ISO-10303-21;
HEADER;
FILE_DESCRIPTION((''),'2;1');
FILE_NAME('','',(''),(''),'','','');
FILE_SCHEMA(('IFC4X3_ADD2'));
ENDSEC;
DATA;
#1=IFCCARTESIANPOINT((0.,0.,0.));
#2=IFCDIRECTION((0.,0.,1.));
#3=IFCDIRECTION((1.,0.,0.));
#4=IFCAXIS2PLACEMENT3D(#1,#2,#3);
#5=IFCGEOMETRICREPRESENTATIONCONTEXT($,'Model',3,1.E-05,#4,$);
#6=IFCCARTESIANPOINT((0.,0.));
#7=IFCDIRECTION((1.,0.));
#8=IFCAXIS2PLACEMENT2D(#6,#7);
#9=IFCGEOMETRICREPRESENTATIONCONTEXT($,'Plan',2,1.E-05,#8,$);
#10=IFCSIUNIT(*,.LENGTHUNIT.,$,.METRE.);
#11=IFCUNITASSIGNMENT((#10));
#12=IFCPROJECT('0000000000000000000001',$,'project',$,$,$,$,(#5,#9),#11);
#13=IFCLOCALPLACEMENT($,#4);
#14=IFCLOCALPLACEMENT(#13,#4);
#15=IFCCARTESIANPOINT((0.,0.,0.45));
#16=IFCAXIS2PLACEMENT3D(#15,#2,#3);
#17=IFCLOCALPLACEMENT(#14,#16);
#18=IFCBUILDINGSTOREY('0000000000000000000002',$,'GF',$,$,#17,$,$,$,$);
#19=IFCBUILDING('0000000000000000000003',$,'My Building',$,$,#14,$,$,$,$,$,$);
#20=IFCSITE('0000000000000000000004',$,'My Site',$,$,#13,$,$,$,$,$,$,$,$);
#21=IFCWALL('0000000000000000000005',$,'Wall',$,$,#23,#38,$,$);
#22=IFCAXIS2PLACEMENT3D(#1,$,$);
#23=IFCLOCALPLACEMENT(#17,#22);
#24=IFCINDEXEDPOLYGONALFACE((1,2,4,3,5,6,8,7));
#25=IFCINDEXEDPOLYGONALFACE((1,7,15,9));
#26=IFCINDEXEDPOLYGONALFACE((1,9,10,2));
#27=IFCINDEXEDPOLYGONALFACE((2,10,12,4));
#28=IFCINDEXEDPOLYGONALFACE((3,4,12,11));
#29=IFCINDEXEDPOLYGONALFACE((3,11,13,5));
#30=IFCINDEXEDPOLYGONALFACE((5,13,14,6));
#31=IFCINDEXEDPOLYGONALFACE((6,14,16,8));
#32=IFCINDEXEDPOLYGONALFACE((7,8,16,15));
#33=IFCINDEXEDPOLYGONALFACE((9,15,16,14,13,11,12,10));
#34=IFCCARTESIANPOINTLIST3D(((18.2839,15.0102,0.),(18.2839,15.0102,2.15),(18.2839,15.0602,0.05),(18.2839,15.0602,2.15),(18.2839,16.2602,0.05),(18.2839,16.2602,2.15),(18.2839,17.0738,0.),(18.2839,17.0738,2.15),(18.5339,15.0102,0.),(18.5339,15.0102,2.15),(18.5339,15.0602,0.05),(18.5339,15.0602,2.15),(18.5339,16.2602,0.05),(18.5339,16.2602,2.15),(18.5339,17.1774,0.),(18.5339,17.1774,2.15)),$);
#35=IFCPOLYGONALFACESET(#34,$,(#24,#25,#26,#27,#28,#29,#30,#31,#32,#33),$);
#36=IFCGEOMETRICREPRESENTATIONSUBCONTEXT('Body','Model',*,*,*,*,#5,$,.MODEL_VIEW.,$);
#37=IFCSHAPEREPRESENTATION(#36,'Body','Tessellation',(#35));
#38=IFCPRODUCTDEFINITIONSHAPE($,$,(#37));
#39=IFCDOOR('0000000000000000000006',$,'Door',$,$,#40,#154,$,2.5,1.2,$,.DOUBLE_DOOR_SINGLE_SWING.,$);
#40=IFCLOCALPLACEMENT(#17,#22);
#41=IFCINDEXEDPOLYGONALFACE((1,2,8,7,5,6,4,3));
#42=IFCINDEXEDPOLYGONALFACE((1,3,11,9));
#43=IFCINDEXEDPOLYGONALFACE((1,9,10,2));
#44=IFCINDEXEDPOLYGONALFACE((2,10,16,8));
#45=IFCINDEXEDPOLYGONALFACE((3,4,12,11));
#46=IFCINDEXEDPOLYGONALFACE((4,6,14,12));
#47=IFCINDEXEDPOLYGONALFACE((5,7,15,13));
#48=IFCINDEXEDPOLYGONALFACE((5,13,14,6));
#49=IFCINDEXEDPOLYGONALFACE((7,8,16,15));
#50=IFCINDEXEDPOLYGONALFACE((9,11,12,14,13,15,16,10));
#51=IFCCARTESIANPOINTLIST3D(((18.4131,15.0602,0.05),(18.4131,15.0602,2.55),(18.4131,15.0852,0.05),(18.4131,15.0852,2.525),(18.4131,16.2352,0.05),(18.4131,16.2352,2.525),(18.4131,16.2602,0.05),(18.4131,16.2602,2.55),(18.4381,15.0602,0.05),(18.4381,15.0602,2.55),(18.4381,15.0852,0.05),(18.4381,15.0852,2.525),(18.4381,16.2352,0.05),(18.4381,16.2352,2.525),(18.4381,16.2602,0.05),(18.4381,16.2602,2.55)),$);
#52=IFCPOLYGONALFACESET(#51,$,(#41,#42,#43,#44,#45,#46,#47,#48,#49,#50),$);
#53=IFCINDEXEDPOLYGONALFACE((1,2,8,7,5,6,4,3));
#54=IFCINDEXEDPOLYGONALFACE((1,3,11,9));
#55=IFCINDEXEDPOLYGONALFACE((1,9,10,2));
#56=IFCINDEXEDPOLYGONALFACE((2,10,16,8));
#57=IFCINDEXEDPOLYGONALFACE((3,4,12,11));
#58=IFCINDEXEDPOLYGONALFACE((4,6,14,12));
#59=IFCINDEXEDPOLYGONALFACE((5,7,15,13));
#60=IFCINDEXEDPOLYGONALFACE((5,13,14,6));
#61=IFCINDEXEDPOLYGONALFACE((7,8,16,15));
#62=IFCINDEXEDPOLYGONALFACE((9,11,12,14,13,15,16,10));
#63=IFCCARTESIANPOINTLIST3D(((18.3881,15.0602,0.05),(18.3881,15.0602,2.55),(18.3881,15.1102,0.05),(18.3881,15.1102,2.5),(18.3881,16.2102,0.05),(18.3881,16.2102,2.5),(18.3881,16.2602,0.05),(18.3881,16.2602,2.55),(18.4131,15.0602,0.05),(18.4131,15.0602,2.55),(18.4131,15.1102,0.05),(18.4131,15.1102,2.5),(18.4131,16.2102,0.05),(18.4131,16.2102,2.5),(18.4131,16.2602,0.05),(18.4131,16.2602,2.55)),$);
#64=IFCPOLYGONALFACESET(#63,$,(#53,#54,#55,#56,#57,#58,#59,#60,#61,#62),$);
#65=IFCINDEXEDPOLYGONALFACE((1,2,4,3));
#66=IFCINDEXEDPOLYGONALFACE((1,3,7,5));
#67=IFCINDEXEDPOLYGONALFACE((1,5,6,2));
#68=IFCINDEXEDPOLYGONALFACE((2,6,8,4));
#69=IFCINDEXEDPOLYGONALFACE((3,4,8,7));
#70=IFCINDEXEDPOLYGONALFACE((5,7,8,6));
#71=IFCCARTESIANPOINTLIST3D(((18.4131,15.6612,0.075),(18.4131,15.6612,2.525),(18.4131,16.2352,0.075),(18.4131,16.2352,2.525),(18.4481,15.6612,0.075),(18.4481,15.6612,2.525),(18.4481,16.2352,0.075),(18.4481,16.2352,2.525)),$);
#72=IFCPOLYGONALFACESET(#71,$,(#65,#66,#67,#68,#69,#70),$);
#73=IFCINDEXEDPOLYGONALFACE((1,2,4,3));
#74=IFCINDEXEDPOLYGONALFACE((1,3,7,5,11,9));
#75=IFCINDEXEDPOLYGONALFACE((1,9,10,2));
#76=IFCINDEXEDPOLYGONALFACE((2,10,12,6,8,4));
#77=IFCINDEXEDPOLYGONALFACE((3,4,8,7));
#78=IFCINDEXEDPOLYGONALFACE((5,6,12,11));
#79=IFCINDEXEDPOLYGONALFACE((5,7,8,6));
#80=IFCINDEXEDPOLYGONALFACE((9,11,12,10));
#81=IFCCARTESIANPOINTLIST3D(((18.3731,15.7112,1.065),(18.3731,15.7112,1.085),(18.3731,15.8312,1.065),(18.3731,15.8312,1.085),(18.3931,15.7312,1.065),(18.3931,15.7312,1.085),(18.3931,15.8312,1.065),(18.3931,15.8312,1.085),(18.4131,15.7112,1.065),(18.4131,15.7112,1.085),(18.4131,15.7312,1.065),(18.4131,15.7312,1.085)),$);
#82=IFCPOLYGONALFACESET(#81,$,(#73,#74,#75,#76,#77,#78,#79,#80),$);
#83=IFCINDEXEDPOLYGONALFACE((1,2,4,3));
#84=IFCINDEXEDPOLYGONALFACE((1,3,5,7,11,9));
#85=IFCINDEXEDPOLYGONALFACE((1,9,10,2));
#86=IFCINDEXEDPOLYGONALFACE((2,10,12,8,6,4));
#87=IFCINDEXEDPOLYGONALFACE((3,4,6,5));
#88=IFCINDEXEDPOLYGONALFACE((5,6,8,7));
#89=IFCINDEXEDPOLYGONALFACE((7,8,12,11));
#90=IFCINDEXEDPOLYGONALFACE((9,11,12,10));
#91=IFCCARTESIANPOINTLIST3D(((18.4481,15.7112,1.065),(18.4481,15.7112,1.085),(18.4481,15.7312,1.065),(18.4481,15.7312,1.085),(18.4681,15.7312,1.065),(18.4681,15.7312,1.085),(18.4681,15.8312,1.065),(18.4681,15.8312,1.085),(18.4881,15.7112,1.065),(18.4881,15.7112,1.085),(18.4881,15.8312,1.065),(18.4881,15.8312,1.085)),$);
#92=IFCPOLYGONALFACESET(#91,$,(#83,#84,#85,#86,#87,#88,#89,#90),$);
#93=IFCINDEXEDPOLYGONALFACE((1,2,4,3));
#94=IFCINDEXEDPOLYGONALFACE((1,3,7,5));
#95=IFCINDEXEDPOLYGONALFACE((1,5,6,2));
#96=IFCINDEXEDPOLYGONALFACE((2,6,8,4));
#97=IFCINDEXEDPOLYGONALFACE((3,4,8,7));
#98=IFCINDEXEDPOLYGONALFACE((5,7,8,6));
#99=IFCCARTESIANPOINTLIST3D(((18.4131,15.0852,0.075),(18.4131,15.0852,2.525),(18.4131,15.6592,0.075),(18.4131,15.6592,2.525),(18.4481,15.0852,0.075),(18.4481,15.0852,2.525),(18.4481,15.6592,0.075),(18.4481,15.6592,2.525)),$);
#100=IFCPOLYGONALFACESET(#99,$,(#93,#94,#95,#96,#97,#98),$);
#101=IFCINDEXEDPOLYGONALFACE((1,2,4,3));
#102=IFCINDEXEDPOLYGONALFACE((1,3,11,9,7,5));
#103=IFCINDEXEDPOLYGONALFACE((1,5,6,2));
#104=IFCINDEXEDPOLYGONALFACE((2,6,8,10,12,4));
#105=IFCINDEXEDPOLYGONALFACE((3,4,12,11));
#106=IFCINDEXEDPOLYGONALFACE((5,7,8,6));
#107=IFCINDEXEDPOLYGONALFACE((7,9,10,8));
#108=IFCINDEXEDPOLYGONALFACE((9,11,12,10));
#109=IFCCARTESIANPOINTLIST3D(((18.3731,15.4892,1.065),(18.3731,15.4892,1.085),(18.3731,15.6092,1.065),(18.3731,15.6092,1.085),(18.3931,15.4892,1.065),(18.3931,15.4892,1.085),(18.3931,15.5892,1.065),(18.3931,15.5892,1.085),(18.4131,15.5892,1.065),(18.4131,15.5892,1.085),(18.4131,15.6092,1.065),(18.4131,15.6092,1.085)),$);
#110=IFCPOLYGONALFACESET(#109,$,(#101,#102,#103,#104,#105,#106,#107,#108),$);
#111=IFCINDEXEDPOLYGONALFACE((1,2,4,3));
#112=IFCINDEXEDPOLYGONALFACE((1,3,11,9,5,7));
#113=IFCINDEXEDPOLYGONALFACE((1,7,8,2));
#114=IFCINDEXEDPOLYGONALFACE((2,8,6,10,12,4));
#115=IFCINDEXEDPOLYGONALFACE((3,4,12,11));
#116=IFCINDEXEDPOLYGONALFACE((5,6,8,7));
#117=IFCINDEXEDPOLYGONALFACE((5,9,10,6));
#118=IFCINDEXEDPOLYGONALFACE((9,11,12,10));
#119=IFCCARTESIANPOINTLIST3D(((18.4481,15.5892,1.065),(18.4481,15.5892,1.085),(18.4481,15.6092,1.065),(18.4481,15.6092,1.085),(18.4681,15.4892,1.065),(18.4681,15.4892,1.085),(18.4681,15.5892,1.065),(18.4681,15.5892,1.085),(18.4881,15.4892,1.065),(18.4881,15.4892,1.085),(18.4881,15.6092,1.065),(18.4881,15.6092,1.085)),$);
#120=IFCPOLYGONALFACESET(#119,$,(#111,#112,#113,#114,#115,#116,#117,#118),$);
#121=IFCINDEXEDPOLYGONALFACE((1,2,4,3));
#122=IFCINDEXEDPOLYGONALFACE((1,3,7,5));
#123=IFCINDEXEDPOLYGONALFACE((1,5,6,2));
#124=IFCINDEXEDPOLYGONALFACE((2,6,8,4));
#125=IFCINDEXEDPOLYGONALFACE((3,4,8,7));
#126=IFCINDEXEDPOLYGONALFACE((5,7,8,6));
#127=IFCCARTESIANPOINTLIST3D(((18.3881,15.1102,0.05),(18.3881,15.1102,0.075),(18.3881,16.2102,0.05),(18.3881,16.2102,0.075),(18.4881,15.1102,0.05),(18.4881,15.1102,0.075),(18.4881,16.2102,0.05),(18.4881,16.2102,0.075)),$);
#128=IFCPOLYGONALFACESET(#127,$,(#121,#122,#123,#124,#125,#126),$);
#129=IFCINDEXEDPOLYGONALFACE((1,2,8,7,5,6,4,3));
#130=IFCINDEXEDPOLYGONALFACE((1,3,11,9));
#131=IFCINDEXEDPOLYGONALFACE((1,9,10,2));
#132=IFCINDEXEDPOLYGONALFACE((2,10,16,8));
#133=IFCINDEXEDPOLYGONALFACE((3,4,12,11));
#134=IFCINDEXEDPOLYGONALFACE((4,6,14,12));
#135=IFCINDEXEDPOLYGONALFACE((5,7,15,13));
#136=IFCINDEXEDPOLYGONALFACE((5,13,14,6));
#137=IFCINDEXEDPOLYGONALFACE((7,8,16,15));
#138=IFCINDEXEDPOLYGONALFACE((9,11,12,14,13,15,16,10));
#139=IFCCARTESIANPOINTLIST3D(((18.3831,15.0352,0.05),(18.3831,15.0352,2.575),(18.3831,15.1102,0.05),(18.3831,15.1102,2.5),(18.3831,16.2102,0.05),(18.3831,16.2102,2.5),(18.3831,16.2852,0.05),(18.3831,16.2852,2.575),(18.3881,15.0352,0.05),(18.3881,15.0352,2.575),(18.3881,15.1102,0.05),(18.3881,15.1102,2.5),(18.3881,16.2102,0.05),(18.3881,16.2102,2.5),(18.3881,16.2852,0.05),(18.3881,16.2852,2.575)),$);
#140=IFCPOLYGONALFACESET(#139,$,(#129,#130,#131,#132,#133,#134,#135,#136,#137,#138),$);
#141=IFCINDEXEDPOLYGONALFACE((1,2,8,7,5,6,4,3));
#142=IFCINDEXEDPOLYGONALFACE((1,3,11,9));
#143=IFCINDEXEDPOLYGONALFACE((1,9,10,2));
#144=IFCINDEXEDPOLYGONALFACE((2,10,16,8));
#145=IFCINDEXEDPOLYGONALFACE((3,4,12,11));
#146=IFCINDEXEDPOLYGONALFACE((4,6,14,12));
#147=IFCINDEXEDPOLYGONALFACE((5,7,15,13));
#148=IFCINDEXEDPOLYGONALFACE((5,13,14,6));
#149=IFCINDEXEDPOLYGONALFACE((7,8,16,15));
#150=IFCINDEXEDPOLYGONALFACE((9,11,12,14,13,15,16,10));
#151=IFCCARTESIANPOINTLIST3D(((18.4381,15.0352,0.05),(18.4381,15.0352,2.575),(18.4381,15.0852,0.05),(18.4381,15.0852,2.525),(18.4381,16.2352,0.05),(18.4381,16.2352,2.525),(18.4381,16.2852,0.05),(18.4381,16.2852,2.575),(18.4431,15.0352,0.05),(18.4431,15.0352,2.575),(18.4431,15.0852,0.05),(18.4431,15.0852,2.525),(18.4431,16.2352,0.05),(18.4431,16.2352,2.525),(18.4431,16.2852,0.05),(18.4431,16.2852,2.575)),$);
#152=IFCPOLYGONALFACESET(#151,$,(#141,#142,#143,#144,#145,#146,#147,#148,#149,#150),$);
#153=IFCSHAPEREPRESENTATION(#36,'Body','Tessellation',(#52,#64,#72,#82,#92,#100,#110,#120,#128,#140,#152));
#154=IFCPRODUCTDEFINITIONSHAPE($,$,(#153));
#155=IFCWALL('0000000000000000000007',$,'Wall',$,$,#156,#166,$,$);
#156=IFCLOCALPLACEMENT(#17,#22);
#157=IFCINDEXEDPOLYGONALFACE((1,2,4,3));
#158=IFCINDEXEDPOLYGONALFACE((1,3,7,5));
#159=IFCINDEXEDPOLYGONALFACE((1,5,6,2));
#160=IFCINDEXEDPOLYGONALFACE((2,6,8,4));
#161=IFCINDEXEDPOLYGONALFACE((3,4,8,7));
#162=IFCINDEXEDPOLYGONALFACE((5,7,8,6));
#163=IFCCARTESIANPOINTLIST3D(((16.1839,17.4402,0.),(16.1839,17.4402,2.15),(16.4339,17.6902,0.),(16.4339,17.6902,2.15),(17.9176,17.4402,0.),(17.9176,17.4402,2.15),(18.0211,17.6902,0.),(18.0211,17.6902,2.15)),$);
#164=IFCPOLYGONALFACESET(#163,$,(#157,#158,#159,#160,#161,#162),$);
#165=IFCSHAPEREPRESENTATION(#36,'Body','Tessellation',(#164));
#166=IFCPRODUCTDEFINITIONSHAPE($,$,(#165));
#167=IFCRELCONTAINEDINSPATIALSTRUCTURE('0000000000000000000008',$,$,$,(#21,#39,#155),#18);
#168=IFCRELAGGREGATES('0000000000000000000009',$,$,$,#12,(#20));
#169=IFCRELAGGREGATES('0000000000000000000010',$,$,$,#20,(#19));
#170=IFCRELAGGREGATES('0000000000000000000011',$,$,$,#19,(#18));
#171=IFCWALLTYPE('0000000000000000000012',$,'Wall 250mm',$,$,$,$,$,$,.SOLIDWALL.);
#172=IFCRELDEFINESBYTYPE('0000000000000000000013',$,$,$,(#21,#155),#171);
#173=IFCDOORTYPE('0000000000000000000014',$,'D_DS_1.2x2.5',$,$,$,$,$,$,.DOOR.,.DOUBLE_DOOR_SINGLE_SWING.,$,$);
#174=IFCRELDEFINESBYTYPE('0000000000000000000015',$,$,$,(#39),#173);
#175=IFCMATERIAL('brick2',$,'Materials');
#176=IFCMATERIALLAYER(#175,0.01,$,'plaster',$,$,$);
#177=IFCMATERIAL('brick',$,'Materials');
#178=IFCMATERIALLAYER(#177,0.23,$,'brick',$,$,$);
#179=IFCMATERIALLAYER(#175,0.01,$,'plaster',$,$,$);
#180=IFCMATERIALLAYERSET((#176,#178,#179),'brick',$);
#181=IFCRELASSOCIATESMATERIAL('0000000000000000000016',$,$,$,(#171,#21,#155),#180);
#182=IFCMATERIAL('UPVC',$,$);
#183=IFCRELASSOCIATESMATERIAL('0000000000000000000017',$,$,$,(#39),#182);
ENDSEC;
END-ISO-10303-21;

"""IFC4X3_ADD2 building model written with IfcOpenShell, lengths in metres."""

from ifc_helpers import new_model, entity, si_unit, frame, origin_with_axes, origin_2d_with_axis, place, context, subcontext, project, spatial, line, indexed_curve, outline, extrude, shape, source, transform, mapped, material, layer, layer_set, layer_usage, type_object, type_shapes, element, fill, save


model = new_model("IFC4X3_ADD2")

# Units and contexts
model_context = context("Model", 3, precision=1e-05, world=origin_with_axes())
plan_context = context("Plan", 2, precision=1e-05, world=origin_2d_with_axis())
body_context_1 = subcontext(model_context, "Body", "Model", "MODEL_VIEW")
body_context_2 = subcontext(plan_context, "Body", "Plan", "PLAN_VIEW")
ifc_project = project(units=[si_unit("LENGTHUNIT", "METRE")], contexts=[model_context, plan_context])

# Site, building, storey
site_placement = place(None, origin_with_axes())
site = spatial("IfcSite", under=ifc_project, at=site_placement, Name="My Site")
building_placement = place(site_placement, origin_with_axes())
building = spatial("IfcBuilding", under=site, at=building_placement, Name="My Building")
storey_placement = place(building_placement, frame((0.0, 0.0, 0.45), z_axis=(0.0, 0.0, 1.0), x_axis=(1.0, 0.0, 0.0)))
storey = spatial("IfcBuildingStorey", under=building, at=storey_placement, Name="GF")

# Shared definitions
ifc_material_1 = material(Name="UPVC")

# Wall, opening, door
ifc_material_2 = material(Name="brick2", Category="Materials")
ifc_layer_1 = layer(ifc_material_2, 0.01, Name="plaster")
ifc_material_3 = material(Name="brick", Category="Materials")
ifc_layer_2 = layer(ifc_material_3, 0.23, Name="brick")
ifc_layer_3 = layer(ifc_material_2, 0.01, Name="plaster")
ifc_layer_set_1 = layer_set([ifc_layer_1, ifc_layer_2, ifc_layer_3], Name="brick")
ifc_layer_usage_1 = layer_usage(ifc_layer_set_1, "AXIS2", "NEGATIVE", 0.0)
wall_type = type_object("IfcWallType", Name="Wall 250mm", PredefinedType="SOLIDWALL", material=ifc_layer_set_1)
wall_1_placement = place(storey_placement, frame((18.2839, 15.0102, 0.0), z_axis=(0.0, 0.0, 1.0), x_axis=(0.000001, 1.0, 0.0)))
wall_1 = element("IfcWall", 1, at=wall_1_placement, inside=storey, type_object=wall_type, material=ifc_layer_usage_1, Name="Wall", context=body_context_1, shape_type="SweptSolid", body=[
    extrude(outline(indexed_curve([(0.0, -0.25), (0.0, 0.0), (2.0636, 0.0), (2.1672, -0.25)], segments=[line(1, 2, 3, 4, 1)])), origin_with_axes(), (0.0, 0.0, 1.0), 2.15),
])
shared_shape_1 = source(origin_with_axes(), body_context_1, "Body", "SweptSolid", [
    extrude(outline(indexed_curve([(0.0, 0.0), (1.2, 0.0), (1.2, 2.5), (0.0, 2.5)], segments=[line(1, 2, 3, 4, 1)])), frame((0.0, -0.6, 0.0), z_axis=(0.0, -1.0, 0.0), x_axis=(1.0, 0.0, 0.0)), (0.0, 0.0, -1.0), 1.2),
])
opening_placement = place(wall_1_placement, frame((1.25, -0.1042, 0.05), z_axis=(0.0, 0.0, 1.0), x_axis=(-1.0, 0.0, 0.0)))
opening = element("IfcOpeningElement", 2, at=opening_placement, cuts=wall_1, PredefinedType="OPENING", context=body_context_1, shape_type="MappedRepresentation", body=[
    mapped(shared_shape_1, transform((0.0, 0.0, 0.0), x_axis=(1.0, 0.0, 0.0), y_axis=(0.0, 1.0, 0.0), z_axis=(0.0, 0.0, 1.0), scale=1.0)),
])
door_type = type_object("IfcDoorType", Name="D_DS_1.2x2.5", OperationType="DOUBLE_DOOR_SINGLE_SWING", PredefinedType="DOOR")
shared_shape_2 = source(origin_with_axes(), body_context_1, "Body", "SweptSolid", [
    extrude(outline(indexed_curve([(0.0, 0.0), (0.0, 2.5), (1.2, 2.5), (1.2, 0.0), (1.175, 0.0), (1.175, 2.475), (0.025, 2.475), (0.025, 0.0)], segments=[line(1, 2, 3, 4, 5, 6, 7, 8, 1)])), frame((0.0, 0.025, 0.0), z_axis=(0.0, -1.0, 0.0), x_axis=(1.0, 0.0, 0.0)), (0.0, 0.0, -1.0), 0.025),
    extrude(outline(indexed_curve([(0.0, 0.0), (0.0, 2.5), (1.2, 2.5), (1.2, 0.0), (1.15, 0.0), (1.15, 2.45), (0.05, 2.45), (0.05, 0.0)], segments=[line(1, 2, 3, 4, 5, 6, 7, 8, 1)])), frame((0.0, 0.0, 0.0), z_axis=(0.0, -1.0, 0.0), x_axis=(1.0, 0.0, 0.0)), (0.0, 0.0, -1.0), 0.025),
    extrude(outline(indexed_curve([(0.0, 0.0), (0.574, 0.0), (0.574, 0.035), (0.0, 0.035)], segments=[line(1, 2, 3, 4, 1)])), frame((0.025, 0.025, 0.025), z_axis=(0.0, 0.0, 1.0), x_axis=(1.0, 0.0, 0.0)), (0.0, 0.0, 1.0), 2.45),
    extrude(outline(indexed_curve([(0.0, 0.0), (0.0, -0.04), (-0.12, -0.04), (-0.12, -0.02), (-0.02, -0.02), (-0.02, 0.0)], segments=[line(1, 2, 3, 4, 5, 6, 1)])), frame((0.549, 0.025, 1.015), z_axis=(0.0, 0.0, 1.0), x_axis=(1.0, 0.0, 0.0)), (0.0, 0.0, 1.0), 0.02),
    extrude(outline(indexed_curve([(0.0, 0.0), (0.0, 0.04), (-0.12, 0.04), (-0.12, 0.02), (-0.02, 0.02), (-0.02, 0.0)], segments=[line(1, 2, 3, 4, 5, 6, 1)])), frame((0.549, 0.06, 1.015), z_axis=(0.0, 0.0, 1.0), x_axis=(1.0, 0.0, 0.0)), (0.0, 0.0, 1.0), 0.02),
    extrude(outline(indexed_curve([(0.0, 0.0), (-0.574, 0.0), (-0.574, 0.035), (0.0, 0.035)], segments=[line(1, 2, 3, 4, 1)])), frame((1.175, 0.025, 0.025), z_axis=(0.0, 0.0, 1.0), x_axis=(1.0, 0.0, 0.0)), (0.0, 0.0, 1.0), 2.45),
    extrude(outline(indexed_curve([(0.0, 0.0), (0.0, -0.04), (0.12, -0.04), (0.12, -0.02), (0.02, -0.02), (0.02, 0.0)], segments=[line(1, 2, 3, 4, 5, 6, 1)])), frame((0.651, 0.025, 1.015), z_axis=(0.0, 0.0, 1.0), x_axis=(1.0, 0.0, 0.0)), (0.0, 0.0, 1.0), 0.02),
    extrude(outline(indexed_curve([(0.0, 0.0), (0.0, 0.04), (0.12, 0.04), (0.12, 0.02), (0.02, 0.02), (0.02, 0.0)], segments=[line(1, 2, 3, 4, 5, 6, 1)])), frame((0.651, 0.06, 1.015), z_axis=(0.0, 0.0, 1.0), x_axis=(1.0, 0.0, 0.0)), (0.0, 0.0, 1.0), 0.02),
    extrude(outline(indexed_curve([(0.0, 0.0), (1.1, 0.0), (1.1, 0.1), (0.0, 0.1)], segments=[line(1, 2, 3, 4, 1)])), frame((0.05, 0.0, 0.0), z_axis=(0.0, 0.0, 1.0), x_axis=(1.0, 0.0, 0.0)), (0.0, 0.0, 1.0), 0.025),
    extrude(outline(indexed_curve([(0.0, 0.0), (0.0, 2.525), (1.25, 2.525), (1.25, 0.0), (1.175, 0.0), (1.175, 2.45), (0.075, 2.45), (0.075, 0.0)], segments=[line(1, 2, 3, 4, 5, 6, 7, 8, 1)])), frame((-0.025, -0.005, 0.0), z_axis=(0.0, -1.0, 0.0), x_axis=(1.0, 0.0, 0.0)), (0.0, 0.0, -1.0), 0.005),
    extrude(outline(indexed_curve([(0.0, 0.0), (0.0, 2.525), (1.25, 2.525), (1.25, 0.0), (1.2, 0.0), (1.2, 2.475), (0.05, 2.475), (0.05, 0.0)], segments=[line(1, 2, 3, 4, 5, 6, 7, 8, 1)])), frame((-0.025, 0.05, 0.0), z_axis=(0.0, -1.0, 0.0), x_axis=(1.0, 0.0, 0.0)), (0.0, 0.0, -1.0), 0.005),
])
shared_shape_3 = source(origin_with_axes(), body_context_2, "Body", "Curve2D", [
    entity("IfcIndexedPolyCurve", entity("IfcCartesianPointList2D", [[0.0, 0.0], [0.0, 0.05], [0.025, 0.05], [0.025, 0.025], [0.05, 0.025], [0.05, 0.0]]), [entity("IfcLineIndex", [1, 2, 3, 4, 5, 6, 1])]),
    entity("IfcIndexedPolyCurve", entity("IfcCartesianPointList2D", [[1.2, 0.0], [1.2, 0.05], [1.175, 0.05], [1.175, 0.025], [1.15, 0.025], [1.15, 0.0]]), [entity("IfcLineIndex", [1, 2, 3, 4, 5, 6, 1])]),
    entity("IfcTrimmedCurve", entity("IfcEllipse", entity("IfcAxis2Placement2D", entity("IfcCartesianPoint", [0.06, 0.05]), entity("IfcDirection", [1.0, 0.0])), 0.54, 0.575), [entity("IfcCartesianPoint", [0.6, 0.05])], [entity("IfcCartesianPoint", [0.06, 0.625])], True, "CARTESIAN"),
    entity("IfcIndexedPolyCurve", entity("IfcCartesianPointList2D", [[0.025, 0.05], [0.06, 0.05], [0.06, 0.625], [0.025, 0.625]]), [entity("IfcLineIndex", [1, 2, 3, 4, 1])]),
    entity("IfcTrimmedCurve", entity("IfcEllipse", entity("IfcAxis2Placement2D", entity("IfcCartesianPoint", [1.14, 0.05]), entity("IfcDirection", [1.0, 0.0])), 0.54, 0.575), [entity("IfcCartesianPoint", [1.14, 0.625])], [entity("IfcCartesianPoint", [0.6, 0.05])], True, "CARTESIAN"),
    entity("IfcIndexedPolyCurve", entity("IfcCartesianPointList2D", [[1.175, 0.05], [1.14, 0.05], [1.14, 0.625], [1.175, 0.625]]), [entity("IfcLineIndex", [1, 2, 3, 4, 1])]),
])
type_shapes(door_type, [shared_shape_2, shared_shape_3])
door_placement = place(opening_placement, frame((0.0, 0.0, 0.0), z_axis=(0.0, 0.0, 1.0), x_axis=(1.0, 0.0, 0.0)))
door = element("IfcDoor", 3, at=door_placement, inside=storey, type_object=door_type, material=ifc_material_1, Name="Door", OperationType="DOUBLE_DOOR_SINGLE_SWING", OverallHeight=2.5, OverallWidth=1.2, shapes=[
    shape(body_context_1, "Body", "MappedRepresentation", [mapped(shared_shape_2, transform((0.0, 0.0, 0.0), x_axis=(1.0, 0.0, 0.0), y_axis=(0.0, 1.0, 0.0), z_axis=(0.0, 0.0, 1.0), scale=1.0))]),
    shape(body_context_2, "Body", "MappedRepresentation", [mapped(shared_shape_3, transform((0.0, 0.0, 0.0), x_axis=(1.0, 0.0, 0.0), y_axis=(0.0, 1.0, 0.0), z_axis=(0.0, 0.0, 1.0), scale=1.0))]),
])
fill(opening, door)

# Wall
ifc_layer_usage_2 = layer_usage(ifc_layer_set_1, "AXIS2", "NEGATIVE", 0.0)
wall_2_placement = place(storey_placement, frame((17.9176, 17.4402, 0.0), z_axis=(0.0, 0.0, 1.0), x_axis=(-1.0, 0.0, 0.0)))
element("IfcWall", 4, at=wall_2_placement, inside=storey, type_object=wall_type, material=ifc_layer_usage_2, Name="Wall", context=body_context_1, shape_type="SweptSolid", body=[
    extrude(outline(indexed_curve([(-0.1036, -0.25), (0.0, 0.0), (1.7336, 0.0), (1.4836, -0.25)], segments=[line(1, 2, 3, 4, 1)])), origin_with_axes(), (0.0, 0.0, 1.0), 2.15),
])

save(model, "model.ifc")
